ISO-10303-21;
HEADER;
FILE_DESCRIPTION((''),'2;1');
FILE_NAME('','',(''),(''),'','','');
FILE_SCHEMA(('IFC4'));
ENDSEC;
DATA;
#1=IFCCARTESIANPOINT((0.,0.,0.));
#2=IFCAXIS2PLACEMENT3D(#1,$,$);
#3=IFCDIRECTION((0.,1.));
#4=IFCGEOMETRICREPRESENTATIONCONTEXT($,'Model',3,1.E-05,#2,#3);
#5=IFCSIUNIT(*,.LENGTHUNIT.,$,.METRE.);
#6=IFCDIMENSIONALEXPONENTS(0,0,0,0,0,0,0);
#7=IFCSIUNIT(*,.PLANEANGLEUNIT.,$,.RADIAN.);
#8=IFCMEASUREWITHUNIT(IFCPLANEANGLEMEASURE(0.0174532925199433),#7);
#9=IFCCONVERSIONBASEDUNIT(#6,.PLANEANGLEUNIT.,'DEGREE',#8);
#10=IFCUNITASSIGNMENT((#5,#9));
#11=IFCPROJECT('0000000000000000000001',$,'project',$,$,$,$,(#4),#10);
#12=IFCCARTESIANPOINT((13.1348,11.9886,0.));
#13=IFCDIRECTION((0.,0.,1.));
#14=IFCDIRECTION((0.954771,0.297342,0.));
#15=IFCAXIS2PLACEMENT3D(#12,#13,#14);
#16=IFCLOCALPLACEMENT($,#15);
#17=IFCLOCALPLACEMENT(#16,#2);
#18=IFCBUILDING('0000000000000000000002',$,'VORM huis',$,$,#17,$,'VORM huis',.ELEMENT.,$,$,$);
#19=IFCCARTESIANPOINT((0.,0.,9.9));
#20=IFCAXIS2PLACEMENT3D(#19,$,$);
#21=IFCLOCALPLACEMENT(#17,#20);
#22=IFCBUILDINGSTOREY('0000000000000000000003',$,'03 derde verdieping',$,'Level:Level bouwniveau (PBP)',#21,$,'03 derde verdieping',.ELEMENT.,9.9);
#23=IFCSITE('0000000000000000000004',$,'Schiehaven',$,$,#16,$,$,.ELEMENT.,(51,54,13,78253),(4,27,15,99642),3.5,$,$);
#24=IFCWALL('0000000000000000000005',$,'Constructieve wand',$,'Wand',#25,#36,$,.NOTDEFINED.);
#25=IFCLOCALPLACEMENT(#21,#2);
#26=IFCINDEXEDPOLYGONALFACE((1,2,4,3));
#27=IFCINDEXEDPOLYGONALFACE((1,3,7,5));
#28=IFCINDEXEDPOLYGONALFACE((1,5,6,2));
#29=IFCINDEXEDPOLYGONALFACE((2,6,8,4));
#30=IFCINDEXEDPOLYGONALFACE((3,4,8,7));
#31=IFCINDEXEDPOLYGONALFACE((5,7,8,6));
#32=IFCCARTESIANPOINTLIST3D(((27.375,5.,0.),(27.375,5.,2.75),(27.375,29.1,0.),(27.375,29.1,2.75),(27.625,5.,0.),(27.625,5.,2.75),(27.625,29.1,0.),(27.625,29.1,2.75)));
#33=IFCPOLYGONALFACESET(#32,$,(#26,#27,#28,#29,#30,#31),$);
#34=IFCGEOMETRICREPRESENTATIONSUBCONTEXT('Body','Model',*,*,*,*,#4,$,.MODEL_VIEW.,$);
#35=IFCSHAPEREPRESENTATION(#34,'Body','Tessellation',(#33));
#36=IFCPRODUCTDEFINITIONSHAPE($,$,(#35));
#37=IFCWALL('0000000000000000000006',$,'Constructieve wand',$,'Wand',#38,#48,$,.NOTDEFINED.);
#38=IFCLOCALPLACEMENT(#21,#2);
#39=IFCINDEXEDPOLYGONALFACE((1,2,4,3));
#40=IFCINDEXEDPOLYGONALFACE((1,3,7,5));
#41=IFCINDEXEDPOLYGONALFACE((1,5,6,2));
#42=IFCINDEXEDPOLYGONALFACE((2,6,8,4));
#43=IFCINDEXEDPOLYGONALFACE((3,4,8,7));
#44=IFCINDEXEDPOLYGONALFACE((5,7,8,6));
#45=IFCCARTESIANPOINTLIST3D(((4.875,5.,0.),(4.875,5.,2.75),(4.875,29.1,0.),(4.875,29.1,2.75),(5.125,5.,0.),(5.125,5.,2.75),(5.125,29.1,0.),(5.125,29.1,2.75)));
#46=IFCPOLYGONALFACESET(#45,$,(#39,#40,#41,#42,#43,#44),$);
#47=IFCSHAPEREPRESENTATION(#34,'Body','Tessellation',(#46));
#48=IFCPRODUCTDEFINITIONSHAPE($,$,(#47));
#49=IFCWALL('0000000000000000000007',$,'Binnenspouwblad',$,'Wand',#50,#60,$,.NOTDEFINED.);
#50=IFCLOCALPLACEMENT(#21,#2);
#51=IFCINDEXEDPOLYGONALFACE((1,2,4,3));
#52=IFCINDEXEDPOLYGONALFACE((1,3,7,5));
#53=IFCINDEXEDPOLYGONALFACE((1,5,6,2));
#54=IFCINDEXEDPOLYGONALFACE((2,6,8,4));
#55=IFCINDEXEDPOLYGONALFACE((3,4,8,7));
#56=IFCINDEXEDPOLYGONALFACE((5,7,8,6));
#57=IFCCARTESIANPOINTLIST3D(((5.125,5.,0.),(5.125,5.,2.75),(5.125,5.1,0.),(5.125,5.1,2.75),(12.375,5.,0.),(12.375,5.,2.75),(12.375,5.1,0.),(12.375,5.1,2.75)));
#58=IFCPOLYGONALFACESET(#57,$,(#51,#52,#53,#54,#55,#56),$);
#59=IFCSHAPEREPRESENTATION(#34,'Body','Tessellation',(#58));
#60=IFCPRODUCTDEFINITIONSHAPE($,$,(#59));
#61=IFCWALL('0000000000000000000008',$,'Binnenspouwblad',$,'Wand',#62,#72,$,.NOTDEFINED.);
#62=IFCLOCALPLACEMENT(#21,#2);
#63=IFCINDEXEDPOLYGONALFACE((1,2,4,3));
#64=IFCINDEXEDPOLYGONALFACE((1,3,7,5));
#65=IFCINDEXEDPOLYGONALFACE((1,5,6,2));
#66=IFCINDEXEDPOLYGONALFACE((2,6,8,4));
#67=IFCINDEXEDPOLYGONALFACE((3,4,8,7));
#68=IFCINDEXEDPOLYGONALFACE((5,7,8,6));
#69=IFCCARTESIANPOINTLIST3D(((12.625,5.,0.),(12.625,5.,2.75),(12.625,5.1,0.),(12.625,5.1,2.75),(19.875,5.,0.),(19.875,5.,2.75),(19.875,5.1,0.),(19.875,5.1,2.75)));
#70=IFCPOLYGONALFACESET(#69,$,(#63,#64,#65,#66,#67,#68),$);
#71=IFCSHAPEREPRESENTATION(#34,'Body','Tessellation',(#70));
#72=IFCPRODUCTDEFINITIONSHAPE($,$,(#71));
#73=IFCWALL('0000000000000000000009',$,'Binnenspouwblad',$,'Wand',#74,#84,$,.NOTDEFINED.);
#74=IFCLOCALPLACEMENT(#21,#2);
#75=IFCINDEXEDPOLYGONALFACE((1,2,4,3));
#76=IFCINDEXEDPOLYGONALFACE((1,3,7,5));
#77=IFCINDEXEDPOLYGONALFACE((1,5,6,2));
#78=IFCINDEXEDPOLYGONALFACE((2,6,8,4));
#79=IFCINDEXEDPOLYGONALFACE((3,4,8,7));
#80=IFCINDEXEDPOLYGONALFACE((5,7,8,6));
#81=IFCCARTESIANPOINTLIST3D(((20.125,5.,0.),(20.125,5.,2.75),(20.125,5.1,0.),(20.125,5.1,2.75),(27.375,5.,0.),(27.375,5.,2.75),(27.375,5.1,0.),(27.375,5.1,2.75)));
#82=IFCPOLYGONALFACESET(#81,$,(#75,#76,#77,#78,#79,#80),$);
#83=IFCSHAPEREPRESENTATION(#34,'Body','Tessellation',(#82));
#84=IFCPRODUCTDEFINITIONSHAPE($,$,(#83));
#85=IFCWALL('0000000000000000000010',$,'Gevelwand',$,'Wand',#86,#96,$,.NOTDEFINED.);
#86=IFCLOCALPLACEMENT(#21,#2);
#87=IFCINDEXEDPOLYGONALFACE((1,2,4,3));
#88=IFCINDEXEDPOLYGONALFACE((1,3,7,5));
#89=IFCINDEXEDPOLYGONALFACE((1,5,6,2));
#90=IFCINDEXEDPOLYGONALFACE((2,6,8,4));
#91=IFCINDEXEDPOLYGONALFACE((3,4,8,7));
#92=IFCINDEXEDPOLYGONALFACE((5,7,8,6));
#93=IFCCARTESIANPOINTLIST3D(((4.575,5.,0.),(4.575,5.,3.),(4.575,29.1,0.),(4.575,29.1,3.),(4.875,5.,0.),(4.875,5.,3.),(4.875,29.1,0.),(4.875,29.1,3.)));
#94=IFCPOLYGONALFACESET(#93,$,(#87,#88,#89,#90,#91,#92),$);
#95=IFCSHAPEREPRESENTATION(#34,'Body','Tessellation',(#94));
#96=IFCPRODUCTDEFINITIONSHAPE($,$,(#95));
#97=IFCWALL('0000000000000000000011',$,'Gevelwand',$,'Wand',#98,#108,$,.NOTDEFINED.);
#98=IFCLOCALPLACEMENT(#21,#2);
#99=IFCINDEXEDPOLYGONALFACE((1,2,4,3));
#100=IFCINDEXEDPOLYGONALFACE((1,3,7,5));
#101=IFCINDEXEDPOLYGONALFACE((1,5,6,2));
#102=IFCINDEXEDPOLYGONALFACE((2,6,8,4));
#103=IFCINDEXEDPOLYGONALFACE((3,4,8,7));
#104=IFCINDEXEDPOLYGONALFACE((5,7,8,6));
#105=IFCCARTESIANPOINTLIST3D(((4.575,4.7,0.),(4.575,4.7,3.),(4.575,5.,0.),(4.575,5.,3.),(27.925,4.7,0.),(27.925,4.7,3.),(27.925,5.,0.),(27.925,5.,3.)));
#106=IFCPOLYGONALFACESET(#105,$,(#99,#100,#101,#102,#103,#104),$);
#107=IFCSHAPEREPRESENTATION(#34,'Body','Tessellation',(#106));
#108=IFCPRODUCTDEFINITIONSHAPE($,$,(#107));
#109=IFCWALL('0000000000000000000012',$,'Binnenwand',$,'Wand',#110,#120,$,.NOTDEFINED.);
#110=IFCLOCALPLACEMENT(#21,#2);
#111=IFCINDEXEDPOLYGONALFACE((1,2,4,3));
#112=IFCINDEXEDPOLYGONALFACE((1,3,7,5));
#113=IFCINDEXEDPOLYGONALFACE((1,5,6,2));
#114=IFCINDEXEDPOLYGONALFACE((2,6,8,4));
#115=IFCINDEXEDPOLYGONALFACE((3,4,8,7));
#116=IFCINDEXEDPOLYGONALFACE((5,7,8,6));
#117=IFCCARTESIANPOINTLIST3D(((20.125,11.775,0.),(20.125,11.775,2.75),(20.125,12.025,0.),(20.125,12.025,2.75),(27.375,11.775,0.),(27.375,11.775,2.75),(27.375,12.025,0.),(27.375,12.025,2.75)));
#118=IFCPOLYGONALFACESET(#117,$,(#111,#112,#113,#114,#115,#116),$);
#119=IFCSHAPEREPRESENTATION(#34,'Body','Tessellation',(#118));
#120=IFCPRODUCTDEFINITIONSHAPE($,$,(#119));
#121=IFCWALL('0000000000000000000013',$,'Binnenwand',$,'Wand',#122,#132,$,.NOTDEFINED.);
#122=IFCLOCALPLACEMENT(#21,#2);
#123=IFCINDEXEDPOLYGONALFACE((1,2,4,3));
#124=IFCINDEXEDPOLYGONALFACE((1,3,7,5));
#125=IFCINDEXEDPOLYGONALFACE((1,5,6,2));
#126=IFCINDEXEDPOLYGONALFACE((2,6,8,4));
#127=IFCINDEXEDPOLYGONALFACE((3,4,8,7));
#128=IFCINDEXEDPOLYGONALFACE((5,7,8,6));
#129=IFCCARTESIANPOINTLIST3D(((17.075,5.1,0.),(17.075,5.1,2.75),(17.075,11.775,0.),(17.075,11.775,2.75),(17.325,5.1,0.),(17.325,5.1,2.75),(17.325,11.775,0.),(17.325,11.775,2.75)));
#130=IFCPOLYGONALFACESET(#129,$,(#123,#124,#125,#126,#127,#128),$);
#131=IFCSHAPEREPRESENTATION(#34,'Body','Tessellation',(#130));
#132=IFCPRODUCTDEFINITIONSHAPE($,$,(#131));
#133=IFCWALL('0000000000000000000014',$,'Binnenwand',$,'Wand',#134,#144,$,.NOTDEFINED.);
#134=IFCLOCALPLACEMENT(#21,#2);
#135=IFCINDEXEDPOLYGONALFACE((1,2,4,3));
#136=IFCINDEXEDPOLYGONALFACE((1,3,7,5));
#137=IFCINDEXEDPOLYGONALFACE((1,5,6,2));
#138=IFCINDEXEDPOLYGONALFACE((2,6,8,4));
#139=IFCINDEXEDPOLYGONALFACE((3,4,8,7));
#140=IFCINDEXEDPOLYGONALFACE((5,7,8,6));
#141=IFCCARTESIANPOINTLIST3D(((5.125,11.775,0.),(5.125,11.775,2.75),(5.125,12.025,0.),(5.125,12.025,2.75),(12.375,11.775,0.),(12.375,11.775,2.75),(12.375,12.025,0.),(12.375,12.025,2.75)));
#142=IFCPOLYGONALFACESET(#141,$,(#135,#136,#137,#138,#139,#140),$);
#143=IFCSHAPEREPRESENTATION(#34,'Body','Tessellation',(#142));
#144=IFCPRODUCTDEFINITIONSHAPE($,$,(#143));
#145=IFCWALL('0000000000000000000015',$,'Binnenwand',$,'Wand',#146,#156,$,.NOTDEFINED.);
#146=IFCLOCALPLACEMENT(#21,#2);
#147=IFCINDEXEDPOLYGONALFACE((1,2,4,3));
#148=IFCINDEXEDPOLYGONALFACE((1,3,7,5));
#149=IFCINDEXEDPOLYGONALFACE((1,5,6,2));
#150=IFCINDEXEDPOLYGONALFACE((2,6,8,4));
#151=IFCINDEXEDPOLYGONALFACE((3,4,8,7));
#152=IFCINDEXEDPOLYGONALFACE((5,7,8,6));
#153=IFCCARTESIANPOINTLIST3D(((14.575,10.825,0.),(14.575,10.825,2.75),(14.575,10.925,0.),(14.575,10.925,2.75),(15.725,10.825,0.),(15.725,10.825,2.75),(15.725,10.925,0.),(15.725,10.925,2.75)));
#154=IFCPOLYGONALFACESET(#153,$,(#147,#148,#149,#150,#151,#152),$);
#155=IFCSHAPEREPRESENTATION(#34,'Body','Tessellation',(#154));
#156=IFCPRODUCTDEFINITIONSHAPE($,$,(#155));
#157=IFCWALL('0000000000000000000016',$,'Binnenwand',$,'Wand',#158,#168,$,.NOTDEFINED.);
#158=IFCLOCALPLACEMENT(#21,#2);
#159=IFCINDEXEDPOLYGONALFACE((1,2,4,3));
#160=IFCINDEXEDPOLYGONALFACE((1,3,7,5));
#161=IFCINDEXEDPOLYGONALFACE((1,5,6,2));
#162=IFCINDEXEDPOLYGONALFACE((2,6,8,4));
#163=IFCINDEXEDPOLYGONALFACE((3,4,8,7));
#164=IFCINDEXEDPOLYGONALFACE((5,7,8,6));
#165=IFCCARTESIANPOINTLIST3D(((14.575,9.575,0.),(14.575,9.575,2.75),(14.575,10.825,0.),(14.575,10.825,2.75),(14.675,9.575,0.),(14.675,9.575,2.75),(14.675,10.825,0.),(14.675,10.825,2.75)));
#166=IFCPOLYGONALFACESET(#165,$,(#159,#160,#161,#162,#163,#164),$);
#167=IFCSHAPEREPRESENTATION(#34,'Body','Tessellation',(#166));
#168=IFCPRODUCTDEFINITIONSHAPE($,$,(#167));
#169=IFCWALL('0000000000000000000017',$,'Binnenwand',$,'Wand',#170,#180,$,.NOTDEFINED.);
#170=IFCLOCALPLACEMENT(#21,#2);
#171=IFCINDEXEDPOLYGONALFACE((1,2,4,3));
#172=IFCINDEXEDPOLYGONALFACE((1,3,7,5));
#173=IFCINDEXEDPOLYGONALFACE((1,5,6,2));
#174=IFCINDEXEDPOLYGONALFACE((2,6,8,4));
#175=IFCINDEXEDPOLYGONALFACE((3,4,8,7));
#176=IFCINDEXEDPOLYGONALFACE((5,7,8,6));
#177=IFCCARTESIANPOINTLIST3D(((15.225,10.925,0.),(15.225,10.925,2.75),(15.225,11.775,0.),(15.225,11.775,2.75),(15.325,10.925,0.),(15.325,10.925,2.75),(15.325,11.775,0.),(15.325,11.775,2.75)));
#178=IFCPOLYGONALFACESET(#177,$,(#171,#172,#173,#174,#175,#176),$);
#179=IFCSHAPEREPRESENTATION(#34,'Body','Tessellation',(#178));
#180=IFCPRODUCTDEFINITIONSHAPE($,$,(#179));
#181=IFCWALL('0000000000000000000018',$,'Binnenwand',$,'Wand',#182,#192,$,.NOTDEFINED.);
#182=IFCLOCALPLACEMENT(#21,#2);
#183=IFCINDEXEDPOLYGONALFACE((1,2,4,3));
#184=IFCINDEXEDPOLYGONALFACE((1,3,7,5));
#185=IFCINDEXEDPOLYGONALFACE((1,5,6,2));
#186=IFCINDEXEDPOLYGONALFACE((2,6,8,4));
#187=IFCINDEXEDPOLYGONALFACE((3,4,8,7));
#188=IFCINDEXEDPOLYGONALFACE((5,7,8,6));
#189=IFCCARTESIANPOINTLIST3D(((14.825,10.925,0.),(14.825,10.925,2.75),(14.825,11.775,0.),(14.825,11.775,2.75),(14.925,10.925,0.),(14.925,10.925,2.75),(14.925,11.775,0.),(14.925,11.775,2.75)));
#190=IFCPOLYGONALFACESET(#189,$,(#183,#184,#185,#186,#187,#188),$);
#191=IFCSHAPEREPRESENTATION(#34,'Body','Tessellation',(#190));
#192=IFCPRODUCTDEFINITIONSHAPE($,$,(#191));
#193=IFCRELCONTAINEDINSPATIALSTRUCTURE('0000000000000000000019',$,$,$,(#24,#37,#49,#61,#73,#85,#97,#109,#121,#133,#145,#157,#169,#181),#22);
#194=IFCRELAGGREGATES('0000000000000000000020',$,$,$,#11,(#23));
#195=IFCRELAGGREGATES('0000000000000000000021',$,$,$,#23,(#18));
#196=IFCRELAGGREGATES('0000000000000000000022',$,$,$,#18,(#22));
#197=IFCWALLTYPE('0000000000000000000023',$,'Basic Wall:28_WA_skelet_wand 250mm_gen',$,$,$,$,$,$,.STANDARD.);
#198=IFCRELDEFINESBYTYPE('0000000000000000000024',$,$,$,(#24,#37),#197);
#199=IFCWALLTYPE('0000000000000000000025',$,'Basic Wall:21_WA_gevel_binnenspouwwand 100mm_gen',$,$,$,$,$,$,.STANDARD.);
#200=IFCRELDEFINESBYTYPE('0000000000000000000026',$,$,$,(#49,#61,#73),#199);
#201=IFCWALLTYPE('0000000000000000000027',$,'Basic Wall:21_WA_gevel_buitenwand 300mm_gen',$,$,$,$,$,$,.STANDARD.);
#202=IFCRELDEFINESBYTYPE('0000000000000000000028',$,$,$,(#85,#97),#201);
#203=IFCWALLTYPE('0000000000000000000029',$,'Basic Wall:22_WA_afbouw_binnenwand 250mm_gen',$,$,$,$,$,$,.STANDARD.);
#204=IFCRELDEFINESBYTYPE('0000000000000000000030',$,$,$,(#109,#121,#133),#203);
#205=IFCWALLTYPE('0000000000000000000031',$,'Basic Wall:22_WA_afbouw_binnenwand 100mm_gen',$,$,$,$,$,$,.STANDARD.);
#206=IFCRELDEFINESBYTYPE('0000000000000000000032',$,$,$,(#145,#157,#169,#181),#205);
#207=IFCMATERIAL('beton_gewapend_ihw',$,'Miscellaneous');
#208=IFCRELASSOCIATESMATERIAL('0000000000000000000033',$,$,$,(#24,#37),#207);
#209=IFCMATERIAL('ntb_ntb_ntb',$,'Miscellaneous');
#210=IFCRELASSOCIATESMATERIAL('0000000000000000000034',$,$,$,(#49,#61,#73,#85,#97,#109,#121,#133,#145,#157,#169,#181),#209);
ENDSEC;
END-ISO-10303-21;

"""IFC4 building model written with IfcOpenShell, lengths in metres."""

from ifc_helpers import new_model, entity, si_unit, converted_unit, direction, frame, origin, place, context, subcontext, project, spatial, indexed_curve, outline, extrude, material, type_object, element, save


model = new_model("IFC4")

# Units and contexts
model_context = context("Model", 3, precision=1e-05, world=origin(), true_north=direction((0.0, 1.0)))
body_context = subcontext(model_context, "Body", "Model", "MODEL_VIEW")
ifc_project = project(units=[si_unit("LENGTHUNIT", "METRE"), converted_unit("PLANEANGLEUNIT", "DEGREE", entity("IfcPlaneAngleMeasure", 0.0174532925199433), si_unit("PLANEANGLEUNIT", "RADIAN"), dimensions=[0, 0, 0, 0, 0, 0, 0])], contexts=[model_context])

# Site, building, storey
site_placement = place(None, frame((13.1348, 11.9886, 0.0), z_axis=(0.0, 0.0, 1.0), x_axis=(0.954771, 0.297342, 0.0)))
site = spatial("IfcSite", under=ifc_project, at=site_placement, Name="Schiehaven", CompositionType="ELEMENT", RefLatitude=(51, 54, 13, 78253), RefLongitude=(4, 27, 15, 99642), RefElevation=3.5)
building_placement = place(site_placement, origin())
building = spatial("IfcBuilding", under=site, at=building_placement, Name="VORM huis", LongName="VORM huis", CompositionType="ELEMENT")
storey_placement = place(building_placement, frame((0.0, 0.0, 9.9)))
storey = spatial("IfcBuildingStorey", under=building, at=storey_placement, Name="03 derde verdieping", ObjectType="Level:Level bouwniveau (PBP)", LongName="03 derde verdieping", CompositionType="ELEMENT", Elevation=9.9)

# Shared definitions
ifc_material_1 = material(Name="beton_gewapend_ihw", Category="Miscellaneous")

# Walls
wall_type_1 = type_object("IfcWallType", Name="Basic Wall:28_WA_skelet_wand 250mm_gen", PredefinedType="STANDARD")
wall_1_placement = place(storey_placement, frame((27.5, 5.0, 0.0), z_axis=(0.0, 0.0, 1.0), x_axis=(0.0, 1.0, 0.0)))
element("IfcWall", 1, at=wall_1_placement, inside=storey, type_object=wall_type_1, material=ifc_material_1, Name="Constructieve wand", ObjectType="Wand", PredefinedType="NOTDEFINED", context=body_context, shape_type="SweptSolid", body=[
    extrude(outline(indexed_curve([(24.1, 0.125), (0.0, 0.125), (0.0, -0.125), (24.1, -0.125), (24.1, 0.125)], self_intersect=False)), origin(), (0.0, 0.0, 1.0), 2.75),
])
wall_2_placement = place(storey_placement, frame((5.0, 5.0, 0.0), z_axis=(0.0, 0.0, 1.0), x_axis=(0.0, 1.0, 0.0)))
element("IfcWall", 2, at=wall_2_placement, inside=storey, type_object=wall_type_1, material=ifc_material_1, Name="Constructieve wand", ObjectType="Wand", PredefinedType="NOTDEFINED", context=body_context, shape_type="SweptSolid", body=[
    extrude(outline(indexed_curve([(24.1, 0.125), (0.0, 0.125), (0.0, -0.125), (24.1, -0.125), (24.1, 0.125)], self_intersect=False)), origin(), (0.0, 0.0, 1.0), 2.75),
])
ifc_material_2 = material(Name="ntb_ntb_ntb", Category="Miscellaneous")
wall_type_2 = type_object("IfcWallType", Name="Basic Wall:21_WA_gevel_binnenspouwwand 100mm_gen", PredefinedType="STANDARD")
wall_3_placement = place(storey_placement, frame((5.125, 5.05, 0.0)))
element("IfcWall", 3, at=wall_3_placement, inside=storey, type_object=wall_type_2, material=ifc_material_2, Name="Binnenspouwblad", ObjectType="Wand", PredefinedType="NOTDEFINED", context=body_context, shape_type="SweptSolid", body=[
    extrude(outline(indexed_curve([(7.25, 0.05), (0.0, 0.05), (0.0, -0.05), (7.25, -0.05), (7.25, 0.05)], self_intersect=False)), origin(), (0.0, 0.0, 1.0), 2.75),
])
wall_4_placement = place(storey_placement, frame((19.875, 5.05, 0.0), z_axis=(0.0, 0.0, 1.0), x_axis=(-1.0, 0.0, 0.0)))
element("IfcWall", 4, at=wall_4_placement, inside=storey, type_object=wall_type_2, material=ifc_material_2, Name="Binnenspouwblad", ObjectType="Wand", PredefinedType="NOTDEFINED", context=body_context, shape_type="SweptSolid", body=[
    extrude(outline(indexed_curve([(7.25, 0.05), (0.0, 0.05), (0.0, -0.05), (7.25, -0.05), (7.25, 0.05)], self_intersect=False)), origin(), (0.0, 0.0, 1.0), 2.75),
])
wall_5_placement = place(storey_placement, frame((20.125, 5.05, 0.0)))
element("IfcWall", 5, at=wall_5_placement, inside=storey, type_object=wall_type_2, material=ifc_material_2, Name="Binnenspouwblad", ObjectType="Wand", PredefinedType="NOTDEFINED", context=body_context, shape_type="SweptSolid", body=[
    extrude(outline(indexed_curve([(7.25, 0.05), (0.0, 0.05), (0.0, -0.05), (7.25, -0.05), (7.25, 0.05)], self_intersect=False)), origin(), (0.0, 0.0, 1.0), 2.75),
])
wall_type_3 = type_object("IfcWallType", Name="Basic Wall:21_WA_gevel_buitenwand 300mm_gen", PredefinedType="STANDARD")
wall_6_placement = place(storey_placement, frame((4.725, 5.0, 0.0), z_axis=(0.0, 0.0, 1.0), x_axis=(0.0, 1.0, 0.0)))
element("IfcWall", 6, at=wall_6_placement, inside=storey, type_object=wall_type_3, material=ifc_material_2, Name="Gevelwand", ObjectType="Wand", PredefinedType="NOTDEFINED", context=body_context, shape_type="SweptSolid", body=[
    extrude(outline(indexed_curve([(24.1, 0.15), (0.0, 0.15), (0.0, -0.15), (24.1, -0.15), (24.1, 0.15)], self_intersect=False)), origin(), (0.0, 0.0, 1.0), 3.0),
])
wall_7_placement = place(storey_placement, frame((27.925, 4.85, 0.0), z_axis=(0.0, 0.0, 1.0), x_axis=(-1.0, 0.0, 0.0)))
element("IfcWall", 7, at=wall_7_placement, inside=storey, type_object=wall_type_3, material=ifc_material_2, Name="Gevelwand", ObjectType="Wand", PredefinedType="NOTDEFINED", context=body_context, shape_type="SweptSolid", body=[
    extrude(outline(indexed_curve([(23.35, 0.15), (0.0, 0.15), (0.0, -0.15), (23.35, -0.15), (23.35, 0.15)], self_intersect=False)), origin(), (0.0, 0.0, 1.0), 3.0),
])
wall_type_4 = type_object("IfcWallType", Name="Basic Wall:22_WA_afbouw_binnenwand 250mm_gen", PredefinedType="STANDARD")
wall_8_placement = place(storey_placement, frame((20.125, 11.9, 0.0)))
element("IfcWall", 8, at=wall_8_placement, inside=storey, type_object=wall_type_4, material=ifc_material_2, Name="Binnenwand", ObjectType="Wand", PredefinedType="NOTDEFINED", context=body_context, shape_type="SweptSolid", body=[
    extrude(outline(indexed_curve([(7.25, 0.125), (0.0, 0.125), (0.0, -0.125), (7.25, -0.125), (7.25, 0.125)], self_intersect=False)), origin(), (0.0, 0.0, 1.0), 2.75),
])
wall_9_placement = place(storey_placement, frame((17.2, 11.775, 0.0), z_axis=(0.0, 0.0, 1.0), x_axis=(0.0, -1.0, 0.0)))
element("IfcWall", 9, at=wall_9_placement, inside=storey, type_object=wall_type_4, material=ifc_material_2, Name="Binnenwand", ObjectType="Wand", PredefinedType="NOTDEFINED", context=body_context, shape_type="SweptSolid", body=[
    extrude(outline(indexed_curve([(6.675, 0.125), (0.0, 0.125), (0.0, -0.125), (6.675, -0.125), (6.675, 0.125)], self_intersect=False)), origin(), (0.0, 0.0, 1.0), 2.75),
])
wall_10_placement = place(storey_placement, frame((12.375, 11.9, 0.0), z_axis=(0.0, 0.0, 1.0), x_axis=(-1.0, 0.0, 0.0)))
element("IfcWall", 10, at=wall_10_placement, inside=storey, type_object=wall_type_4, material=ifc_material_2, Name="Binnenwand", ObjectType="Wand", PredefinedType="NOTDEFINED", context=body_context, shape_type="SweptSolid", body=[
    extrude(outline(indexed_curve([(7.25, 0.125), (0.0, 0.125), (0.0, -0.125), (7.25, -0.125), (7.25, 0.125)], self_intersect=False)), origin(), (0.0, 0.0, 1.0), 2.75),
])
wall_type_5 = type_object("IfcWallType", Name="Basic Wall:22_WA_afbouw_binnenwand 100mm_gen", PredefinedType="STANDARD")
wall_11_placement = place(storey_placement, frame((14.575, 10.875, 0.0)))
element("IfcWall", 11, at=wall_11_placement, inside=storey, type_object=wall_type_5, material=ifc_material_2, Name="Binnenwand", ObjectType="Wand", PredefinedType="NOTDEFINED", context=body_context, shape_type="SweptSolid", body=[
    extrude(outline(indexed_curve([(1.15, 0.05), (0.0, 0.05), (0.0, -0.05), (1.15, -0.05), (1.15, 0.05)], self_intersect=False)), origin(), (0.0, 0.0, 1.0), 2.75),
])
wall_12_placement = place(storey_placement, frame((14.625, 10.825, 0.0), z_axis=(0.0, 0.0, 1.0), x_axis=(0.0, -1.0, 0.0)))
element("IfcWall", 12, at=wall_12_placement, inside=storey, type_object=wall_type_5, material=ifc_material_2, Name="Binnenwand", ObjectType="Wand", PredefinedType="NOTDEFINED", context=body_context, shape_type="SweptSolid", body=[
    extrude(outline(indexed_curve([(1.25, 0.05), (0.0, 0.05), (0.0, -0.05), (1.25, -0.05), (1.25, 0.05)], self_intersect=False)), origin(), (0.0, 0.0, 1.0), 2.75),
])
wall_13_placement = place(storey_placement, frame((15.275, 11.775, 0.0), z_axis=(0.0, 0.0, 1.0), x_axis=(0.0, -1.0, 0.0)))
element("IfcWall", 13, at=wall_13_placement, inside=storey, type_object=wall_type_5, material=ifc_material_2, Name="Binnenwand", ObjectType="Wand", PredefinedType="NOTDEFINED", context=body_context, shape_type="SweptSolid", body=[
    extrude(outline(indexed_curve([(0.85, 0.05), (0.0, 0.05), (0.0, -0.05), (0.85, -0.05), (0.85, 0.05)], self_intersect=False)), origin(), (0.0, 0.0, 1.0), 2.75),
])
wall_14_placement = place(storey_placement, frame((14.875, 11.775, 0.0), z_axis=(0.0, 0.0, 1.0), x_axis=(0.0, -1.0, 0.0)))
element("IfcWall", 14, at=wall_14_placement, inside=storey, type_object=wall_type_5, material=ifc_material_2, Name="Binnenwand", ObjectType="Wand", PredefinedType="NOTDEFINED", context=body_context, shape_type="SweptSolid", body=[
    extrude(outline(indexed_curve([(0.85, 0.05), (0.0, 0.05), (0.0, -0.05), (0.85, -0.05), (0.85, 0.05)], self_intersect=False)), origin(), (0.0, 0.0, 1.0), 2.75),
])

save(model, "model.ifc")
